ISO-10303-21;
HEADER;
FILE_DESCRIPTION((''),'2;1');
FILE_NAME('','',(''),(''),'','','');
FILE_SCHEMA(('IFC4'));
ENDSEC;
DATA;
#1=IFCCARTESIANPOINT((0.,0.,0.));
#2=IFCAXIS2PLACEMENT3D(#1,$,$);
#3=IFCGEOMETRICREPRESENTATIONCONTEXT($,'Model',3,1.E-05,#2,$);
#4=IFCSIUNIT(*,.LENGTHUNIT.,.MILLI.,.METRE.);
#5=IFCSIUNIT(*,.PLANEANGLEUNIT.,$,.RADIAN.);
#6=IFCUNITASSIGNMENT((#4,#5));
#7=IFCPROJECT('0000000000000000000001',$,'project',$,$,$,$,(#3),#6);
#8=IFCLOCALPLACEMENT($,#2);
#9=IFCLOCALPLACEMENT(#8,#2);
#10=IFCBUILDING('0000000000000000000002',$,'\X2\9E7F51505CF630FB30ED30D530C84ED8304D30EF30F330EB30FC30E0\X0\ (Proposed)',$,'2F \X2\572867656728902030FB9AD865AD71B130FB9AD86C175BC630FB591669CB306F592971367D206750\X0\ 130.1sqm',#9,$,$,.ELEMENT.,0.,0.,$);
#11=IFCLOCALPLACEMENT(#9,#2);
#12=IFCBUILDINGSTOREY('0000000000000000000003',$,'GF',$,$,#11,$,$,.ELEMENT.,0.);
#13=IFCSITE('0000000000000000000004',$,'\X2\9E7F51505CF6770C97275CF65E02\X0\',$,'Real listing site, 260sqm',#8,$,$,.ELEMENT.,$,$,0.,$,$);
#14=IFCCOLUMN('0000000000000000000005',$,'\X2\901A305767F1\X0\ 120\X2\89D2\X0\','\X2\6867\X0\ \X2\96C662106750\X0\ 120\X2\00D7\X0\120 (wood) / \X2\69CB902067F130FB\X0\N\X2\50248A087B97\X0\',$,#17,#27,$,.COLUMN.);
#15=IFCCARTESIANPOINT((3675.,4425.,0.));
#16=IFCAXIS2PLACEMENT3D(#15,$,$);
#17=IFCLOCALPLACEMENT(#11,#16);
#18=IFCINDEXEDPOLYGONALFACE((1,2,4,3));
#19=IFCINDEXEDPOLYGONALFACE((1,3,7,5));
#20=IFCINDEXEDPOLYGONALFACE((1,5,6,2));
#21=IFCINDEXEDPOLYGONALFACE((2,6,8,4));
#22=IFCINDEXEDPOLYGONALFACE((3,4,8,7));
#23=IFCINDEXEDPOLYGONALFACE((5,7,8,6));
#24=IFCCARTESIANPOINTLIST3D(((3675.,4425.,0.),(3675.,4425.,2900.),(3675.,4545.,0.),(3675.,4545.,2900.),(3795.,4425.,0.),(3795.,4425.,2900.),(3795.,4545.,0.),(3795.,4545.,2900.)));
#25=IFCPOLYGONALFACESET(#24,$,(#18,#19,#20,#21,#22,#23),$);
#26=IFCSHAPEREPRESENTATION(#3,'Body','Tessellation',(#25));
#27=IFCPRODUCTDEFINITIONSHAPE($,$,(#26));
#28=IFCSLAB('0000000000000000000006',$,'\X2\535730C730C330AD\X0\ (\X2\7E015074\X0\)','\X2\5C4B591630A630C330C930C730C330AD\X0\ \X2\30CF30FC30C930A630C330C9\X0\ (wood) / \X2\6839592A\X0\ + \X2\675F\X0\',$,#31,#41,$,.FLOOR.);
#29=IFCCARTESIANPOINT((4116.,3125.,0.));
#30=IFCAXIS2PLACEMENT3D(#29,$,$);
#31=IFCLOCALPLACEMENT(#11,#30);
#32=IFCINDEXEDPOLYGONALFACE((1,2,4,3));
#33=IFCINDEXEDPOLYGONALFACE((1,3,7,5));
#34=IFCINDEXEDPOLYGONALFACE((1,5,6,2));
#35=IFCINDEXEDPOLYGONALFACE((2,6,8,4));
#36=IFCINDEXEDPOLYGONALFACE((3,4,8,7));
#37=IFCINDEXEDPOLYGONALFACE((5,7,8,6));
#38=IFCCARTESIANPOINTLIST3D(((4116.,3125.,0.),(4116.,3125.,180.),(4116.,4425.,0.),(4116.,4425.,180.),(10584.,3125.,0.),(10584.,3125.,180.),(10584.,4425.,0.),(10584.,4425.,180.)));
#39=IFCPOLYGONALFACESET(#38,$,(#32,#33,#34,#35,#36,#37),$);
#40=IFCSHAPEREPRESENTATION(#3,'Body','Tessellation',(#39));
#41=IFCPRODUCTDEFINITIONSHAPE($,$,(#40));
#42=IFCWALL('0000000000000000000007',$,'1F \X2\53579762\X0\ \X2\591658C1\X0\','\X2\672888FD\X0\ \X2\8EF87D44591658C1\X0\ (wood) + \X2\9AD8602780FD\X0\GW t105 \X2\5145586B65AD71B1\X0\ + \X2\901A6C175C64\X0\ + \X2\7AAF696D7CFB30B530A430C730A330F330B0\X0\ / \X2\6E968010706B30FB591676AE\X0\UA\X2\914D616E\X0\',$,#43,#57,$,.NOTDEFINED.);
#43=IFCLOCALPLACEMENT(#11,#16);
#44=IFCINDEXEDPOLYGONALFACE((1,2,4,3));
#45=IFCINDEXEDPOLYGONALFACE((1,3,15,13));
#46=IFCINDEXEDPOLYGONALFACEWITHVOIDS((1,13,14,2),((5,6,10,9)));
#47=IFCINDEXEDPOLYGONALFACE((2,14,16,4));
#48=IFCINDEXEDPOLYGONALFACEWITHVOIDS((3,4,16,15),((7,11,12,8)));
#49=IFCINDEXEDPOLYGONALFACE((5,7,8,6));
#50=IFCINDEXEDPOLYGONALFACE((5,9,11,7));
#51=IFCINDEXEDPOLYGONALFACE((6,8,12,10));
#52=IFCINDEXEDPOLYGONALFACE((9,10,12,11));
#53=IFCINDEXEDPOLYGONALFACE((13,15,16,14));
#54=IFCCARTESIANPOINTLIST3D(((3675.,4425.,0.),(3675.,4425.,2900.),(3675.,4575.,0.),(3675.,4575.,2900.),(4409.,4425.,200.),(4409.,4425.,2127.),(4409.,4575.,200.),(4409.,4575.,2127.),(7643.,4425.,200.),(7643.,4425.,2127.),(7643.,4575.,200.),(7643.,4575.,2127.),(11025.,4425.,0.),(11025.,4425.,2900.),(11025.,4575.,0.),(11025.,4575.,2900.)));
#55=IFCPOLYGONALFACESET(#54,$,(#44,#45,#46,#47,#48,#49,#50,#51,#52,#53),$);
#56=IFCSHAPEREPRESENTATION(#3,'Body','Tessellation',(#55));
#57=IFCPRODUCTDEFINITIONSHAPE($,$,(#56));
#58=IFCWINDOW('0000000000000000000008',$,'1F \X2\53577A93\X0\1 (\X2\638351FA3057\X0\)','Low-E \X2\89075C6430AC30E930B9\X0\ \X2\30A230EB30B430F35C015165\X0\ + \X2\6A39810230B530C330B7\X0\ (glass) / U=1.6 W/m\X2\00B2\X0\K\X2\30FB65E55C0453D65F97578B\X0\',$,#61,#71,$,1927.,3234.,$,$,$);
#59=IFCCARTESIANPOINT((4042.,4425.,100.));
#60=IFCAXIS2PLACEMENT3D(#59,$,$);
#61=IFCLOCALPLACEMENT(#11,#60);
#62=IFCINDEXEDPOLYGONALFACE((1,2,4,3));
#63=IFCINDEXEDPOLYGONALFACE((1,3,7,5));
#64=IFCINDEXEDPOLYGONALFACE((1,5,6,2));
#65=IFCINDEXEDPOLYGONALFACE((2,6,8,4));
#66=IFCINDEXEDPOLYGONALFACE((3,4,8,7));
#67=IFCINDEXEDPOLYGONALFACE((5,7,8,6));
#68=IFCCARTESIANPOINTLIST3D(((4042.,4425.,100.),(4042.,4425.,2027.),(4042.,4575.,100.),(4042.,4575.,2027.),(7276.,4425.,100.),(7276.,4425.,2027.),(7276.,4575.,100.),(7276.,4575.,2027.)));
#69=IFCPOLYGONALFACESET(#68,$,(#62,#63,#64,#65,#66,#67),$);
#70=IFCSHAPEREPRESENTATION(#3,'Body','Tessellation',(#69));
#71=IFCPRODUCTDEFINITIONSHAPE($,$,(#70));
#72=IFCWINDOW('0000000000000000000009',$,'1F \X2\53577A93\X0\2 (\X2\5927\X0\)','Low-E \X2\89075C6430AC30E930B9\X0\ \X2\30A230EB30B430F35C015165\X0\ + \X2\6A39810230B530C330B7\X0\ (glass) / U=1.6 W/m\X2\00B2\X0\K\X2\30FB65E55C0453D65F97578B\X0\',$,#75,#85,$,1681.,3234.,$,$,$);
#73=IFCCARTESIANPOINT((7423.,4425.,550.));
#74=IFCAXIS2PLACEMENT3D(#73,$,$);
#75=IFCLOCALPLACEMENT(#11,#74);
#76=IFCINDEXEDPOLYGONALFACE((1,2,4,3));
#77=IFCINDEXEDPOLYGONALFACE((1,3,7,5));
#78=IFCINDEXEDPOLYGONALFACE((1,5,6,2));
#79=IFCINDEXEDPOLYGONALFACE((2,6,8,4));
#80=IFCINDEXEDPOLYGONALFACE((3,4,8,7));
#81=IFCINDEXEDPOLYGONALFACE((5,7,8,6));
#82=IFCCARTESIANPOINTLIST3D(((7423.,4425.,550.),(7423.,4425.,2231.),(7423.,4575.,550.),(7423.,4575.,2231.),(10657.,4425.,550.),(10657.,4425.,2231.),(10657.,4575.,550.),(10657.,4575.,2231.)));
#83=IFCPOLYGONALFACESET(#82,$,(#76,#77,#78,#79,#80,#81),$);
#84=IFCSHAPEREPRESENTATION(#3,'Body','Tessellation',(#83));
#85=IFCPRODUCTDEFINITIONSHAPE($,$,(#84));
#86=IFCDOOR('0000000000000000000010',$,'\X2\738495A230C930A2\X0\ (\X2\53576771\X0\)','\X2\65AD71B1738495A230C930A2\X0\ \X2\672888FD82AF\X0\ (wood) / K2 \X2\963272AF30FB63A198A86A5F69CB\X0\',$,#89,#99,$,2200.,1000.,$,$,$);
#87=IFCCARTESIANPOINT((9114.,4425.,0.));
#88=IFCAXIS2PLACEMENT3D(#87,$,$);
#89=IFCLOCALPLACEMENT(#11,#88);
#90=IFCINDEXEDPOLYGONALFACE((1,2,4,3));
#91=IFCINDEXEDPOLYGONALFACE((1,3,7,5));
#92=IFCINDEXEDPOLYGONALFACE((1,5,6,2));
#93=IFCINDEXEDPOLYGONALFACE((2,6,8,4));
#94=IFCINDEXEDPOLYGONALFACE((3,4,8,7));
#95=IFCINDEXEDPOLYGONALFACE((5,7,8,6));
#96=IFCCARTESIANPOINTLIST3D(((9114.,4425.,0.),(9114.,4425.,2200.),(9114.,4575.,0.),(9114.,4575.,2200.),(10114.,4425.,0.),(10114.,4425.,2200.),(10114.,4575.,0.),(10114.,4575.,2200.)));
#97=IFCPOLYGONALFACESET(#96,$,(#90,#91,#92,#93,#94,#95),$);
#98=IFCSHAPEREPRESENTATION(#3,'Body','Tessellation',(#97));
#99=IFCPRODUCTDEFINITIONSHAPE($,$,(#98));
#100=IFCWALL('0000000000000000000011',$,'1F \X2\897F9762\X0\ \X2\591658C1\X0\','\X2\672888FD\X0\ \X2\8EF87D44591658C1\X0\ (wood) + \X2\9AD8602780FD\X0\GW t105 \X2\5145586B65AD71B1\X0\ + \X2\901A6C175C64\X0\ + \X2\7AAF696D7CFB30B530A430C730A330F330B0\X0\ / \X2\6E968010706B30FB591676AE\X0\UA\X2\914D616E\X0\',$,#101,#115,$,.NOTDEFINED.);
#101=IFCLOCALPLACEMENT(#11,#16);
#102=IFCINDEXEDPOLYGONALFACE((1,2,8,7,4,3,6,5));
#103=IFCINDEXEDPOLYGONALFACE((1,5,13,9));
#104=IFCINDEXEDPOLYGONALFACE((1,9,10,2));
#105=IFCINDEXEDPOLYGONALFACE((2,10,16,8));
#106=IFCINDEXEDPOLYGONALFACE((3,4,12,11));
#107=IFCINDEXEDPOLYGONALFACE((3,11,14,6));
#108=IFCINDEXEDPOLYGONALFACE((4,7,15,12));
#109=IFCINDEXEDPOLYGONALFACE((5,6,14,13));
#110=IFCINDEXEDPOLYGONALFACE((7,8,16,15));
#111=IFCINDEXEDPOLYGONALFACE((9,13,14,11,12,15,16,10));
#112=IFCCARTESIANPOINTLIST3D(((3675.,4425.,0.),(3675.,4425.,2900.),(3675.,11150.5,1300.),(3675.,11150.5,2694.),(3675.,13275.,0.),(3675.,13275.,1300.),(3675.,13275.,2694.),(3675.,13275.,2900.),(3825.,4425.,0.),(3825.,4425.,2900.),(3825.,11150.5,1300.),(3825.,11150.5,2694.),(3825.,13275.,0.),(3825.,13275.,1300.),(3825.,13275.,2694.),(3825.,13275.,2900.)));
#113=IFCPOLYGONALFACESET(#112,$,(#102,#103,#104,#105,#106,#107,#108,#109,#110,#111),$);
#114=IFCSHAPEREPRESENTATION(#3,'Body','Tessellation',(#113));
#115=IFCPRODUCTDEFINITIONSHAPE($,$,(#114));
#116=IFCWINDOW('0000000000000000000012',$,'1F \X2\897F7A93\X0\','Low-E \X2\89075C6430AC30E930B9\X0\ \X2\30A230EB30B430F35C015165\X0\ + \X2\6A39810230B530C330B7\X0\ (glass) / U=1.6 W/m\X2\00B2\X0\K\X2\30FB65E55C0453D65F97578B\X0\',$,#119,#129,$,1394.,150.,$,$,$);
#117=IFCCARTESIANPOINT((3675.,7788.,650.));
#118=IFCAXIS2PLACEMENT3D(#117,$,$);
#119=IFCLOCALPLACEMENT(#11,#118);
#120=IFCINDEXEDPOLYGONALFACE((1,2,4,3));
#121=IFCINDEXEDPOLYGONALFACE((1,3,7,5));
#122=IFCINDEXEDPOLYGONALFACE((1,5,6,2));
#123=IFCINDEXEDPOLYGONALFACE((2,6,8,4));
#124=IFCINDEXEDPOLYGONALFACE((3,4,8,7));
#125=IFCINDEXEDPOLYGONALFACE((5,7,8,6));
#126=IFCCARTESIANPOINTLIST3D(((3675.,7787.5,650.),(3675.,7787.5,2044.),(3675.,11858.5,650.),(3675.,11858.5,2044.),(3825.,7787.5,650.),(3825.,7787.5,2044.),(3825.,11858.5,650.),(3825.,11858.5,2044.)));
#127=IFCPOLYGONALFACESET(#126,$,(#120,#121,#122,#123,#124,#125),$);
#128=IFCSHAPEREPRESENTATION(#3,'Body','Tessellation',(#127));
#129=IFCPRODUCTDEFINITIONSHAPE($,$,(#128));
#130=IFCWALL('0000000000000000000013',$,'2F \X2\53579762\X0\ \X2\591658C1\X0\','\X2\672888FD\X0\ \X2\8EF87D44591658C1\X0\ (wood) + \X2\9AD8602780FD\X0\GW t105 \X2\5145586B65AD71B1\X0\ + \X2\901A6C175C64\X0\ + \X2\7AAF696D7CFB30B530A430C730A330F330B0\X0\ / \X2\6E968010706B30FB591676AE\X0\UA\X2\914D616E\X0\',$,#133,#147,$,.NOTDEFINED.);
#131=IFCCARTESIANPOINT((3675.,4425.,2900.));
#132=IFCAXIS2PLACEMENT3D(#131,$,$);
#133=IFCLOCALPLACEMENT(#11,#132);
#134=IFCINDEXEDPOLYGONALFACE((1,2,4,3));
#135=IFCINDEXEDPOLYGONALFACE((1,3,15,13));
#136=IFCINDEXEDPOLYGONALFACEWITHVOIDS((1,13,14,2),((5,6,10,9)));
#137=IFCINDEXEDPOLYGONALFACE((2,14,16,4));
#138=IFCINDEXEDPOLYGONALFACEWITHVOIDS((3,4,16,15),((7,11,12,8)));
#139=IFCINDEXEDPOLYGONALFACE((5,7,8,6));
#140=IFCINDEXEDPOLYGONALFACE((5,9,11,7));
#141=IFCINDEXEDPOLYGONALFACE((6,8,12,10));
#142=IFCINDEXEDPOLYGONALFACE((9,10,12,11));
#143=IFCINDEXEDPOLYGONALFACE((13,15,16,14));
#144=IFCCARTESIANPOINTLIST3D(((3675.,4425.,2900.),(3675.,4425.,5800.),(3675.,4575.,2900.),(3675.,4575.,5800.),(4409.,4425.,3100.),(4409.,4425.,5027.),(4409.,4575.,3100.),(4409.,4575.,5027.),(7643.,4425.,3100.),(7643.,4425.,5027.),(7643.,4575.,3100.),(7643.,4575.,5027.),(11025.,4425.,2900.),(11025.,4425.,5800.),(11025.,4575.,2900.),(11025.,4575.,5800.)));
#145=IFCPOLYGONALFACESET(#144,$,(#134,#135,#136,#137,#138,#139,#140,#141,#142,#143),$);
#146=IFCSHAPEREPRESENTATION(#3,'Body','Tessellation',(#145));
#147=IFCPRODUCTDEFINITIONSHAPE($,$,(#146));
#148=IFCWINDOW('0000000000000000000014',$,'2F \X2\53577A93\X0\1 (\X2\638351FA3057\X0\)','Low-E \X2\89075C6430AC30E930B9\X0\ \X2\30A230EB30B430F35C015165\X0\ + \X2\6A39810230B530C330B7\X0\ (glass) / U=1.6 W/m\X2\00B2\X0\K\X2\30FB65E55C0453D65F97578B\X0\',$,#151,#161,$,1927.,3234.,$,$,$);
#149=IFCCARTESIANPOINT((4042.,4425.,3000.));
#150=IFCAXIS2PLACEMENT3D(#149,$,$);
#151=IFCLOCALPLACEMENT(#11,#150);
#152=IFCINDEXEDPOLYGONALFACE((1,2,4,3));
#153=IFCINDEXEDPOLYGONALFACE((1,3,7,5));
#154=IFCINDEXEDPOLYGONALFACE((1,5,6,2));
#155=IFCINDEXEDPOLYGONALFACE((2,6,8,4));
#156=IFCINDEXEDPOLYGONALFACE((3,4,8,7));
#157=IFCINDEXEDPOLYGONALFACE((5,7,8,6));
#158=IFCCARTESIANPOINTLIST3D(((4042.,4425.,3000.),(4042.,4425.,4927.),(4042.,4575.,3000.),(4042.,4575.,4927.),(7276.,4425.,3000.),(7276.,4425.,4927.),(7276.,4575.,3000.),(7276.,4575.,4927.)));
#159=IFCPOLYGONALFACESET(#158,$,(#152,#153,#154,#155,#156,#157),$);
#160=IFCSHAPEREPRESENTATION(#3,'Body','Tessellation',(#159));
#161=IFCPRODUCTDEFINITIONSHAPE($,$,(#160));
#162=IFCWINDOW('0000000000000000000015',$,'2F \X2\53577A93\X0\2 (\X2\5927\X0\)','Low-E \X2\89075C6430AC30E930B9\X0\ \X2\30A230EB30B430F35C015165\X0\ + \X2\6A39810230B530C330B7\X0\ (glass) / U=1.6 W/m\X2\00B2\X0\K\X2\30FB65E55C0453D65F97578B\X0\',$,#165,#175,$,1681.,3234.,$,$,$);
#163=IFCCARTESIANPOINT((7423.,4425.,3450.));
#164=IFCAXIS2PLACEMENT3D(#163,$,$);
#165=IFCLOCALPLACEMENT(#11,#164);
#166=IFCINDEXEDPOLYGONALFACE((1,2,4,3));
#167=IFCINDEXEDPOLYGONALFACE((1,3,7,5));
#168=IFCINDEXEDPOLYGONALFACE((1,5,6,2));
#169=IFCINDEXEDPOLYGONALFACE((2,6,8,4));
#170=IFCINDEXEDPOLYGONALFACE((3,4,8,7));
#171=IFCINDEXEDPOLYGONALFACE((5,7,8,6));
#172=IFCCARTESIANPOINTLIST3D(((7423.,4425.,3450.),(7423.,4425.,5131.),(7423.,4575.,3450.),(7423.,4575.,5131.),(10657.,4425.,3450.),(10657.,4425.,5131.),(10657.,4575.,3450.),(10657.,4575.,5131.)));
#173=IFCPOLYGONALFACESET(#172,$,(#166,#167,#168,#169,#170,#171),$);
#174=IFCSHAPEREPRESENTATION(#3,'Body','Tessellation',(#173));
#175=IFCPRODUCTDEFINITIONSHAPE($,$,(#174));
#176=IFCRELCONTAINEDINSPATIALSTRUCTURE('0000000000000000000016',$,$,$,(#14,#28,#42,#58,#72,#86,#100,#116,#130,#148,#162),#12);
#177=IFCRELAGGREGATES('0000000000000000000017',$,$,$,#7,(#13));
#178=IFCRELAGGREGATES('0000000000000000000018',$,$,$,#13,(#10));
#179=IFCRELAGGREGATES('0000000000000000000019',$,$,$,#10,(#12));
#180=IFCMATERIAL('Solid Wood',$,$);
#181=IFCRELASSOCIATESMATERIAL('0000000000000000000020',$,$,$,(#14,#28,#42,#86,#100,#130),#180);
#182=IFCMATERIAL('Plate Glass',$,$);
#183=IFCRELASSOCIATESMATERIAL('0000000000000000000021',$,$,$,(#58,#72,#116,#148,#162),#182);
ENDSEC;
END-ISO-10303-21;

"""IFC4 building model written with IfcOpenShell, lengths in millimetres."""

from ifc_helpers import new_model, si_unit, frame, frame_2d, origin, place, context, project, spatial, rectangle, extrude, material, element, fill, save


model = new_model("IFC4")

# Units and contexts
model_context = context("Model", 3, precision=1e-05, world=origin())
ifc_project = project(units=[si_unit("LENGTHUNIT", "METRE", prefix="MILLI"), si_unit("PLANEANGLEUNIT", "RADIAN")], contexts=[model_context])

# Site, building, storey
site_placement = place(None, origin())
site = spatial("IfcSite", under=ifc_project, at=site_placement, Name="鹿児島県霧島市", ObjectType="Real listing site, 260sqm", CompositionType="ELEMENT", RefElevation=0.0)
building_placement = place(site_placement, origin())
building = spatial("IfcBuilding", under=site, at=building_placement, Name="鹿児島・ロフト付きワンルーム (Proposed)", ObjectType="2F 在来木造・高断熱・高気密・外構は天然素材 130.1sqm", CompositionType="ELEMENT", ElevationOfRefHeight=0.0, ElevationOfTerrain=0.0)
storey_placement = place(building_placement, origin())
storey = spatial("IfcBuildingStorey", under=building, at=storey_placement, Name="GF", CompositionType="ELEMENT", Elevation=0.0)

# Column
ifc_material_1 = material(Name="Solid Wood")
column_placement = place(storey_placement, frame((3675.0, 4425.0, 0.0)))
element("IfcColumn", 1, at=column_placement, inside=storey, material=ifc_material_1, Name="通し柱 120角", Description="桧 集成材 120×120 (wood) / 構造柱・N値計算", PredefinedType="COLUMN", context=model_context, shape_type="SweptSolid", body=[
    extrude(rectangle(XDim=120.0, YDim=120.0, at=frame_2d((60.0, 60.0))), frame((3675.0, 4425.0, 0.0)), (0.0, 0.0, 1.0), 2900.0),
])

# Slab
slab_1_placement = place(storey_placement, frame((4116.0, 3125.0, 0.0)))
element("IfcSlab", 2, at=slab_1_placement, inside=storey, material=ifc_material_1, Name="南デッキ (縁側)", Description="屋外ウッドデッキ ハードウッド (wood) / 根太 + 束", PredefinedType="FLOOR", context=model_context, shape_type="SweptSolid", body=[
    extrude(rectangle(XDim=6468.0, YDim=1300.0, at=frame_2d((3234.0, 650.0))), frame((4116.0, 3125.0, 0.0)), (0.0, 0.0, 1.0), 180.0),
])

# Wall, openings, windows, door
wall_1_placement = place(storey_placement, frame((3675.0, 4425.0, 0.0)))
wall_1 = element("IfcWall", 3, at=wall_1_placement, inside=storey, material=ifc_material_1, Name="1F 南面 外壁", Description="木製 軸組外壁 (wood) + 高性能GW t105 充填断熱 + 通気層 + 窯業系サイディング / 準耐火・外皮UA配慮", PredefinedType="NOTDEFINED", context=model_context, shape_type="SweptSolid", body=[
    extrude(rectangle(XDim=7350.0, YDim=150.0, at=frame_2d((3675.0, 75.0))), frame((3675.0, 4425.0, 0.0)), (0.0, 0.0, 1.0), 2900.0),
])
opening_1_placement = place(storey_placement, frame((4042.0, 4425.0, 100.0)))
opening_1 = element("IfcOpeningElement", 4, at=opening_1_placement, cuts=wall_1, PredefinedType="NOTDEFINED", context=model_context, shape_type="SweptSolid", body=[
    extrude(rectangle(XDim=3234.0, YDim=150.0, at=frame_2d((1617.0, 75.0))), frame((4042.0, 4425.0, 100.0)), (0.0, 0.0, 1.0), 1927.0),
])
opening_2_placement = place(storey_placement, frame((7423.0, 4425.0, 550.0)))
opening_2 = element("IfcOpeningElement", 5, at=opening_2_placement, cuts=wall_1, PredefinedType="NOTDEFINED", context=model_context, shape_type="SweptSolid", body=[
    extrude(rectangle(XDim=3234.0, YDim=150.0, at=frame_2d((1617.0, 75.0))), frame((7423.0, 4425.0, 550.0)), (0.0, 0.0, 1.0), 1681.0),
])
opening_3_placement = place(storey_placement, frame((9114.0, 4425.0, 0.0)))
opening_3 = element("IfcOpeningElement", 6, at=opening_3_placement, cuts=wall_1, PredefinedType="NOTDEFINED", context=model_context, shape_type="SweptSolid", body=[
    extrude(rectangle(XDim=1000.0, YDim=150.0, at=frame_2d((500.0, 75.0))), frame((9114.0, 4425.0, 0.0)), (0.0, 0.0, 1.0), 2200.0),
])
ifc_material_2 = material(Name="Plate Glass")
window_1_placement = place(storey_placement, frame((4042.0, 4425.0, 100.0)))
window_1 = element("IfcWindow", 7, at=window_1_placement, inside=storey, material=ifc_material_2, Name="1F 南窓1 (掃出し)", Description="Low-E 複層ガラス アルゴン封入 + 樹脂サッシ (glass) / U=1.6 W/m²K・日射取得型", OverallHeight=1927.0, OverallWidth=3234.0, context=model_context, shape_type="SweptSolid", body=[
    extrude(rectangle(XDim=3234.0, YDim=150.0, at=frame_2d((1617.0, 75.0))), frame((4042.0, 4425.0, 100.0)), (0.0, 0.0, 1.0), 1927.0),
])
fill(opening_1, window_1)
window_2_placement = place(storey_placement, frame((7423.0, 4425.0, 550.0)))
window_2 = element("IfcWindow", 8, at=window_2_placement, inside=storey, material=ifc_material_2, Name="1F 南窓2 (大)", Description="Low-E 複層ガラス アルゴン封入 + 樹脂サッシ (glass) / U=1.6 W/m²K・日射取得型", OverallHeight=1681.0, OverallWidth=3234.0, context=model_context, shape_type="SweptSolid", body=[
    extrude(rectangle(XDim=3234.0, YDim=150.0, at=frame_2d((1617.0, 75.0))), frame((7423.0, 4425.0, 550.0)), (0.0, 0.0, 1.0), 1681.0),
])
fill(opening_2, window_2)
door_placement = place(storey_placement, frame((9114.0, 4425.0, 0.0)))
door = element("IfcDoor", 9, at=door_placement, inside=storey, material=ifc_material_1, Name="玄関ドア (南東)", Description="断熱玄関ドア 木製芯 (wood) / K2 防犯・採風機構", OverallHeight=2200.0, OverallWidth=1000.0, context=model_context, shape_type="SweptSolid", body=[
    extrude(rectangle(XDim=1000.0, YDim=150.0, at=frame_2d((500.0, 75.0))), frame((9114.0, 4425.0, 0.0)), (0.0, 0.0, 1.0), 2200.0),
])
fill(opening_3, door)

# Wall, opening, window
wall_2_placement = place(storey_placement, frame((3675.0, 4425.0, 0.0)))
wall_2 = element("IfcWall", 10, at=wall_2_placement, inside=storey, material=ifc_material_1, Name="1F 西面 外壁", Description="木製 軸組外壁 (wood) + 高性能GW t105 充填断熱 + 通気層 + 窯業系サイディング / 準耐火・外皮UA配慮", PredefinedType="NOTDEFINED", context=model_context, shape_type="SweptSolid", body=[
    extrude(rectangle(XDim=150.0, YDim=8850.0, at=frame_2d((75.0, 4425.0))), frame((3675.0, 4425.0, 0.0)), (0.0, 0.0, 1.0), 2900.0),
])
opening_4_placement = place(storey_placement, frame((3675.0, 7788.0, 650.0)))
opening_4 = element("IfcOpeningElement", 11, at=opening_4_placement, cuts=wall_2, PredefinedType="NOTDEFINED", context=model_context, shape_type="SweptSolid", body=[
    extrude(rectangle(XDim=150.0, YDim=4071.0, at=frame_2d((75.0, 2035.0))), frame((3675.0, 7788.0, 650.0)), (0.0, 0.0, 1.0), 1394.0),
])
window_3_placement = place(storey_placement, frame((3675.0, 7788.0, 650.0)))
window_3 = element("IfcWindow", 12, at=window_3_placement, inside=storey, material=ifc_material_2, Name="1F 西窓", Description="Low-E 複層ガラス アルゴン封入 + 樹脂サッシ (glass) / U=1.6 W/m²K・日射取得型", OverallHeight=1394.0, OverallWidth=150.0, context=model_context, shape_type="SweptSolid", body=[
    extrude(rectangle(XDim=150.0, YDim=4071.0, at=frame_2d((75.0, 2035.0))), frame((3675.0, 7788.0, 650.0)), (0.0, 0.0, 1.0), 1394.0),
])
fill(opening_4, window_3)

# Wall, openings, windows
wall_3_placement = place(storey_placement, frame((3675.0, 4425.0, 2900.0)))
wall_3 = element("IfcWall", 13, at=wall_3_placement, inside=storey, material=ifc_material_1, Name="2F 南面 外壁", Description="木製 軸組外壁 (wood) + 高性能GW t105 充填断熱 + 通気層 + 窯業系サイディング / 準耐火・外皮UA配慮", PredefinedType="NOTDEFINED", context=model_context, shape_type="SweptSolid", body=[
    extrude(rectangle(XDim=7350.0, YDim=150.0, at=frame_2d((3675.0, 75.0))), frame((3675.0, 4425.0, 2900.0)), (0.0, 0.0, 1.0), 2900.0),
])
opening_5_placement = place(storey_placement, frame((4042.0, 4425.0, 3000.0)))
opening_5 = element("IfcOpeningElement", 14, at=opening_5_placement, cuts=wall_3, PredefinedType="NOTDEFINED", context=model_context, shape_type="SweptSolid", body=[
    extrude(rectangle(XDim=3234.0, YDim=150.0, at=frame_2d((1617.0, 75.0))), frame((4042.0, 4425.0, 3000.0)), (0.0, 0.0, 1.0), 1927.0),
])
opening_6_placement = place(storey_placement, frame((7423.0, 4425.0, 3450.0)))
opening_6 = element("IfcOpeningElement", 15, at=opening_6_placement, cuts=wall_3, PredefinedType="NOTDEFINED", context=model_context, shape_type="SweptSolid", body=[
    extrude(rectangle(XDim=3234.0, YDim=150.0, at=frame_2d((1617.0, 75.0))), frame((7423.0, 4425.0, 3450.0)), (0.0, 0.0, 1.0), 1681.0),
])
window_4_placement = place(storey_placement, frame((4042.0, 4425.0, 3000.0)))
window_4 = element("IfcWindow", 16, at=window_4_placement, inside=storey, material=ifc_material_2, Name="2F 南窓1 (掃出し)", Description="Low-E 複層ガラス アルゴン封入 + 樹脂サッシ (glass) / U=1.6 W/m²K・日射取得型", OverallHeight=1927.0, OverallWidth=3234.0, context=model_context, shape_type="SweptSolid", body=[
    extrude(rectangle(XDim=3234.0, YDim=150.0, at=frame_2d((1617.0, 75.0))), frame((4042.0, 4425.0, 3000.0)), (0.0, 0.0, 1.0), 1927.0),
])
fill(opening_5, window_4)
window_5_placement = place(storey_placement, frame((7423.0, 4425.0, 3450.0)))
window_5 = element("IfcWindow", 17, at=window_5_placement, inside=storey, material=ifc_material_2, Name="2F 南窓2 (大)", Description="Low-E 複層ガラス アルゴン封入 + 樹脂サッシ (glass) / U=1.6 W/m²K・日射取得型", OverallHeight=1681.0, OverallWidth=3234.0, context=model_context, shape_type="SweptSolid", body=[
    extrude(rectangle(XDim=3234.0, YDim=150.0, at=frame_2d((1617.0, 75.0))), frame((7423.0, 4425.0, 3450.0)), (0.0, 0.0, 1.0), 1681.0),
])
fill(opening_6, window_5)

save(model, "model.ifc")
